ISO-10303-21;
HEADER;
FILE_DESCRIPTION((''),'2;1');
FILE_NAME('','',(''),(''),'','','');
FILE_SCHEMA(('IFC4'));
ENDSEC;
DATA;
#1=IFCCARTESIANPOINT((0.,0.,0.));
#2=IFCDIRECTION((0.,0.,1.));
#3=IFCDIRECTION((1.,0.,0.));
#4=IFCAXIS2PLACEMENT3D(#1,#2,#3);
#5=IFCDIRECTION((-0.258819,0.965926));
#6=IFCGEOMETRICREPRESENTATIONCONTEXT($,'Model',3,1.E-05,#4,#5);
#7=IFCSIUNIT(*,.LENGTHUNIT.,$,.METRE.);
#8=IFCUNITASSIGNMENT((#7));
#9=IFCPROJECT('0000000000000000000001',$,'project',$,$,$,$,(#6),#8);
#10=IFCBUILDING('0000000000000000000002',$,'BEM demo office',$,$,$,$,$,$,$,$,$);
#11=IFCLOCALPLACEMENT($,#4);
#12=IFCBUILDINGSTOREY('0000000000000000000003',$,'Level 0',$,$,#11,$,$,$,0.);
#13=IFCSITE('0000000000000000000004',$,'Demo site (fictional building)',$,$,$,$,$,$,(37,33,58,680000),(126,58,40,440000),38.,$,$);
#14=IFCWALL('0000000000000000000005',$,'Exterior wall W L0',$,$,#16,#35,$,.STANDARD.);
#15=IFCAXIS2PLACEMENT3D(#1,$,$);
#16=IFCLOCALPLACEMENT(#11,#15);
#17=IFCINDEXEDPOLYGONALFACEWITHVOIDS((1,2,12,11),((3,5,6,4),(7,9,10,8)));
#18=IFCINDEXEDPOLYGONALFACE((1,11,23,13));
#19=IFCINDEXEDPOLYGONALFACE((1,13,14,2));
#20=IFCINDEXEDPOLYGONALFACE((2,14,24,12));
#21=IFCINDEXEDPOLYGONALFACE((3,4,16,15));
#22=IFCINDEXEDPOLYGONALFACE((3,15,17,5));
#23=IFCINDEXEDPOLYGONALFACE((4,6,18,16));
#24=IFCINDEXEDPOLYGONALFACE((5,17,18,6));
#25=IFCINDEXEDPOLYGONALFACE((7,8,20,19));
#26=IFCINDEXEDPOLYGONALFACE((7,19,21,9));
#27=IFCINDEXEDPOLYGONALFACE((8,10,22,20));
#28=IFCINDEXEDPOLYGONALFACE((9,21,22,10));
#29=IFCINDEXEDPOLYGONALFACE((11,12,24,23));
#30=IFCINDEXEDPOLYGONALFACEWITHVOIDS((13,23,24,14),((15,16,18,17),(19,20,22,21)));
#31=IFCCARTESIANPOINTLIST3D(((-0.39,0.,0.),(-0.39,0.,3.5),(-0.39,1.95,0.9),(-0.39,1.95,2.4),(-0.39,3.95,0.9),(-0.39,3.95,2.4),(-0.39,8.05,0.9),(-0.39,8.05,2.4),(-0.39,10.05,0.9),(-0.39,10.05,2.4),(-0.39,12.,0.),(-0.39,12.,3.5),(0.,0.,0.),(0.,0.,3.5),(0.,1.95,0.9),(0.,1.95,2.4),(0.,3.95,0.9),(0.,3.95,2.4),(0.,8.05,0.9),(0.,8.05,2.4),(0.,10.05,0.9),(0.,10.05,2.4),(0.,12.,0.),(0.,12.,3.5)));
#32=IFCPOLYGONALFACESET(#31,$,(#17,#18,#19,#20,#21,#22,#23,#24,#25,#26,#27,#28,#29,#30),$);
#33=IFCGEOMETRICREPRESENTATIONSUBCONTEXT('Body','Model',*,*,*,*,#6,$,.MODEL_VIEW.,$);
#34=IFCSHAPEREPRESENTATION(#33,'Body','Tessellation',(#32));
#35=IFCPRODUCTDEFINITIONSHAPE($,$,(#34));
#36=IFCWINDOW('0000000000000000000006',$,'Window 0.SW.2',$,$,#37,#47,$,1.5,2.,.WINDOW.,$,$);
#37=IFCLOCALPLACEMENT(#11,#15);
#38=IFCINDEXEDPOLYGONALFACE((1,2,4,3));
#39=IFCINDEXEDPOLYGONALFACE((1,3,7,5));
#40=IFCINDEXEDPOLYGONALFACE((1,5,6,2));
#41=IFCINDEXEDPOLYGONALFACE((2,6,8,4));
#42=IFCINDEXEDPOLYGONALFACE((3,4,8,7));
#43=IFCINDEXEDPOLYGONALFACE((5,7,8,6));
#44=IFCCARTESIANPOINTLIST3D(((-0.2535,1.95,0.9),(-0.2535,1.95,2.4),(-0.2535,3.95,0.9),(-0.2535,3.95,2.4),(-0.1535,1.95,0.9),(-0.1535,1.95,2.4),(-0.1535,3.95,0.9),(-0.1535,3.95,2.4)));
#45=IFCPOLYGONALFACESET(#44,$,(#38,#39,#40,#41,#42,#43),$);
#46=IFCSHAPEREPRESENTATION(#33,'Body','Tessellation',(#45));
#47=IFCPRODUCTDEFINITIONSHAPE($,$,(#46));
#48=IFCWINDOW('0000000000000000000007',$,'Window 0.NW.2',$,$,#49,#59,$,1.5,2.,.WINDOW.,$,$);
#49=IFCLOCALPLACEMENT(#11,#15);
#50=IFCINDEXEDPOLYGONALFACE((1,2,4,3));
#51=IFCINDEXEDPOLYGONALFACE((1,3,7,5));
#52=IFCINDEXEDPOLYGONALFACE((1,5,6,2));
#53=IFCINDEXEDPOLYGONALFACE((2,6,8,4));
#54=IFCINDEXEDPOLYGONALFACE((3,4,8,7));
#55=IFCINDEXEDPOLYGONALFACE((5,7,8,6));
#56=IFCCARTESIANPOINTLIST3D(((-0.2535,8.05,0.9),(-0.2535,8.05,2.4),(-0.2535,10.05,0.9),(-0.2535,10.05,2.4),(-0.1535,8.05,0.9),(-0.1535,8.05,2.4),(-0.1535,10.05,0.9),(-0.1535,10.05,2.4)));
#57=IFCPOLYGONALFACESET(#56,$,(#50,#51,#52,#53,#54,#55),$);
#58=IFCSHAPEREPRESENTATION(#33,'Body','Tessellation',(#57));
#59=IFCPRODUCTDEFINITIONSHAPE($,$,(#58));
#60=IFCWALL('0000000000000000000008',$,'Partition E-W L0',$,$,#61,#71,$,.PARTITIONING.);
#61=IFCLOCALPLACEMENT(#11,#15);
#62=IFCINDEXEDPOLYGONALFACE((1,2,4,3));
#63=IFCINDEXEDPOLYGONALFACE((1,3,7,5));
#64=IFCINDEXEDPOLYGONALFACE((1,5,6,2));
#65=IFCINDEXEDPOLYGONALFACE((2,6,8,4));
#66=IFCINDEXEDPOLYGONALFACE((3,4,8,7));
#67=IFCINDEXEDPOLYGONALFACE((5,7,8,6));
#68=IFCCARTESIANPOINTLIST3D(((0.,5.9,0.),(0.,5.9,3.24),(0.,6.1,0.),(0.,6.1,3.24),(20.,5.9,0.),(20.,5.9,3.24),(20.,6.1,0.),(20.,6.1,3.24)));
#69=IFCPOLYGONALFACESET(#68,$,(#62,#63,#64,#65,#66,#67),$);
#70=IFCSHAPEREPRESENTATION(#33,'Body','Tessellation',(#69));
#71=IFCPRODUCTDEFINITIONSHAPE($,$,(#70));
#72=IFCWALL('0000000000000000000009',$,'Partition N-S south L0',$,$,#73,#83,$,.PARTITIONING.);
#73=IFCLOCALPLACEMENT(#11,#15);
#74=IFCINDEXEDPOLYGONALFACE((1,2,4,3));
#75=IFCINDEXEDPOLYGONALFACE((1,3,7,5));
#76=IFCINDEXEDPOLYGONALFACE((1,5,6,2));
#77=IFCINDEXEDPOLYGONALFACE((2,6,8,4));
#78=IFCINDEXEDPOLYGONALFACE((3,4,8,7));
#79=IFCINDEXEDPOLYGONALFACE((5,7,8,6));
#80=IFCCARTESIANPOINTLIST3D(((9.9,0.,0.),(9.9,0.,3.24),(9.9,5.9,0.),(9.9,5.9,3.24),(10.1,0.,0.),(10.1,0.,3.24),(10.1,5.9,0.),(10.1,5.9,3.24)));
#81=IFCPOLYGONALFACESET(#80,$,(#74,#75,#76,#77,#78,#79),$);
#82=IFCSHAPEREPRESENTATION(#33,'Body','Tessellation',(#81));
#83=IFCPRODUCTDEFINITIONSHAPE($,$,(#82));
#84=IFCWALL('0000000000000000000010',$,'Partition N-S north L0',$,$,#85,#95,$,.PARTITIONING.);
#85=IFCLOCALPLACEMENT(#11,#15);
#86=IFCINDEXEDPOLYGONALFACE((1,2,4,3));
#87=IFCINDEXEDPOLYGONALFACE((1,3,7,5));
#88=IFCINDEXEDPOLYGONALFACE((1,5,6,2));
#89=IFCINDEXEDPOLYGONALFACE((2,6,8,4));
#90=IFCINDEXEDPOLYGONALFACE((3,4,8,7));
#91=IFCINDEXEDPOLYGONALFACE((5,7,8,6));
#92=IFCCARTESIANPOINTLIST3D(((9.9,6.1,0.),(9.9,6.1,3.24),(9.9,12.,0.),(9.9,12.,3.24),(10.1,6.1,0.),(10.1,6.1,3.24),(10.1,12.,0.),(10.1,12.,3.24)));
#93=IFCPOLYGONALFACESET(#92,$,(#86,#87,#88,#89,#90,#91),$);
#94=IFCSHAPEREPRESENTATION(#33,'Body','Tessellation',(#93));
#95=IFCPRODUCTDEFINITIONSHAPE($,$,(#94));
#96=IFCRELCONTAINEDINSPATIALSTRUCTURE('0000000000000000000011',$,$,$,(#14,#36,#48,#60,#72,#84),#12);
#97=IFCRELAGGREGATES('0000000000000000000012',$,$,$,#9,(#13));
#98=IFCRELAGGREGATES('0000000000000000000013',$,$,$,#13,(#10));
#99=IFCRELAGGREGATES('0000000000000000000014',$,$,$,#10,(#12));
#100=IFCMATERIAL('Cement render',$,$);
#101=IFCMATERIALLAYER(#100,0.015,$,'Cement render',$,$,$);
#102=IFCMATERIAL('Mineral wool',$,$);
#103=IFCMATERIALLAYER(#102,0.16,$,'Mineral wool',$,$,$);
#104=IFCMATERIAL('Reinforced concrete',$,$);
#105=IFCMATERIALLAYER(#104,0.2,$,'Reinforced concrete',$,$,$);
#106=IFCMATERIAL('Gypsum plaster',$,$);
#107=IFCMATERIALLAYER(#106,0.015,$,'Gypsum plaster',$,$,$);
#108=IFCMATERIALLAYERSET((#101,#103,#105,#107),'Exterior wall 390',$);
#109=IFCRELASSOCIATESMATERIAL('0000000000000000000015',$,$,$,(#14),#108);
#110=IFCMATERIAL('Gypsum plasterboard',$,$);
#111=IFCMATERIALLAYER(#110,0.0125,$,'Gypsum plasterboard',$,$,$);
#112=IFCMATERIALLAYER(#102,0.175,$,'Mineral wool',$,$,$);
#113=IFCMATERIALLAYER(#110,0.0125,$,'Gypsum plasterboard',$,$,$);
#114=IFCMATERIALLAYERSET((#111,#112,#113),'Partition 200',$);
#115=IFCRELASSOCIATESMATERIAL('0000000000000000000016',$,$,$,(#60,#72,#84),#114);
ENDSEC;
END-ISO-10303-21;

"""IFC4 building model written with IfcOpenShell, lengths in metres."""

from ifc_helpers import new_model, si_unit, direction, frame, frame_2d, origin, origin_with_axes, place, context, subcontext, project, spatial, rectangle, extrude, material, layer, layer_set, layer_usage, element, fill, save


model = new_model("IFC4")

# Units and contexts
model_context = context("Model", 3, precision=1e-05, world=origin_with_axes(), true_north=direction((-0.258819, 0.965926)))
body_context = subcontext(model_context, "Body", "Model", "MODEL_VIEW")
ifc_project = project(units=[si_unit("LENGTHUNIT", "METRE")], contexts=[model_context])

# Site, building, storey
site = spatial("IfcSite", under=ifc_project, Name="Demo site (fictional building)", RefLatitude=(37, 33, 58, 680000), RefLongitude=(126, 58, 40, 440000), RefElevation=38.0)
building = spatial("IfcBuilding", under=site, Name="BEM demo office")
storey_placement = place(None, origin_with_axes())
storey = spatial("IfcBuildingStorey", under=building, at=storey_placement, Name="Level 0", Elevation=0.0)

# Shared definitions
ifc_material_1 = material(Name="Reinforced concrete")

# Wall, openings, windows
ifc_material_2 = material(Name="Cement render")
ifc_layer_1 = layer(ifc_material_2, 0.015, Name="Cement render")
ifc_material_3 = material(Name="Mineral wool")
ifc_layer_2 = layer(ifc_material_3, 0.16, Name="Mineral wool")
ifc_layer_3 = layer(ifc_material_1, 0.2, Name="Reinforced concrete")
ifc_material_4 = material(Name="Gypsum plaster")
ifc_layer_4 = layer(ifc_material_4, 0.015, Name="Gypsum plaster")
ifc_layer_set_1 = layer_set([ifc_layer_1, ifc_layer_2, ifc_layer_3, ifc_layer_4], Name="Exterior wall 390")
ifc_layer_usage_1 = layer_usage(ifc_layer_set_1, "AXIS2", "POSITIVE", 0.0)
wall_1_placement = place(storey_placement, frame((-0.39, 12.0, 0.0), z_axis=(0.0, 0.0, 1.0), x_axis=(0.0, -1.0, 0.0)))
wall_1 = element("IfcWall", 1, at=wall_1_placement, inside=storey, material=ifc_layer_usage_1, Name="Exterior wall W L0", PredefinedType="STANDARD", context=body_context, shape_type="SweptSolid", body=[
    extrude(rectangle(XDim=12.0, YDim=0.39, at=frame_2d((6.0, 0.195))), origin(), (0.0, 0.0, 1.0), 3.5),
])
opening_1_placement = place(wall_1_placement, origin())
opening_1 = element("IfcOpeningElement", 2, at=opening_1_placement, cuts=wall_1, PredefinedType="OPENING", context=body_context, shape_type="SweptSolid", body=[
    extrude(rectangle(XDim=2.0, YDim=0.49, at=frame_2d((1.0, 0.245))), frame((8.05, -0.05, 0.9)), (0.0, 0.0, 1.0), 1.5),
])
opening_2_placement = place(wall_1_placement, origin())
opening_2 = element("IfcOpeningElement", 3, at=opening_2_placement, cuts=wall_1, PredefinedType="OPENING", context=body_context, shape_type="SweptSolid", body=[
    extrude(rectangle(XDim=2.0, YDim=0.49, at=frame_2d((1.0, 0.245))), frame((1.95, -0.05, 0.9)), (0.0, 0.0, 1.0), 1.5),
])
window_1_placement = place(opening_1_placement, origin_with_axes())
window_1 = element("IfcWindow", 4, at=window_1_placement, inside=storey, Name="Window 0.SW.2", OverallHeight=1.5, OverallWidth=2.0, PredefinedType="WINDOW", context=body_context, shape_type="SweptSolid", body=[
    extrude(rectangle(XDim=2.0, YDim=0.1, at=frame_2d((1.0, 0.05))), frame((8.05, 0.1365, 0.9)), (0.0, 0.0, 1.0), 1.5),
])
fill(opening_1, window_1)
window_2_placement = place(opening_2_placement, origin_with_axes())
window_2 = element("IfcWindow", 5, at=window_2_placement, inside=storey, Name="Window 0.NW.2", OverallHeight=1.5, OverallWidth=2.0, PredefinedType="WINDOW", context=body_context, shape_type="SweptSolid", body=[
    extrude(rectangle(XDim=2.0, YDim=0.1, at=frame_2d((1.0, 0.05))), frame((1.95, 0.1365, 0.9)), (0.0, 0.0, 1.0), 1.5),
])
fill(opening_2, window_2)

# Walls
ifc_material_5 = material(Name="Gypsum plasterboard")
ifc_layer_5 = layer(ifc_material_5, 0.0125, Name="Gypsum plasterboard")
ifc_layer_6 = layer(ifc_material_3, 0.175, Name="Mineral wool")
ifc_layer_7 = layer(ifc_material_5, 0.0125, Name="Gypsum plasterboard")
ifc_layer_set_2 = layer_set([ifc_layer_5, ifc_layer_6, ifc_layer_7], Name="Partition 200")
ifc_layer_usage_2 = layer_usage(ifc_layer_set_2, "AXIS2", "POSITIVE", 0.0)
wall_2_placement = place(storey_placement, frame((0.0, 5.9, 0.0), z_axis=(0.0, 0.0, 1.0), x_axis=(1.0, 0.0, 0.0)))
element("IfcWall", 6, at=wall_2_placement, inside=storey, material=ifc_layer_usage_2, Name="Partition E-W L0", PredefinedType="PARTITIONING", context=body_context, shape_type="SweptSolid", body=[
    extrude(rectangle(XDim=20.0, YDim=0.2, at=frame_2d((10.0, 0.1))), origin(), (0.0, 0.0, 1.0), 3.24),
])
for number, where, z_axis, x_axis, name in (
    (7, (10.1, 0.0, 0.0), (0.0, 0.0, 1.0), (0.0, 1.0, 0.0), "Partition N-S south L0"),
    (8, (10.1, 6.1, 0.0), (0.0, 0.0, 1.0), (0.0, 1.0, 0.0), "Partition N-S north L0"),
):
    element("IfcWall", number, at=place(storey_placement, frame(where, z_axis=z_axis, x_axis=x_axis)), inside=storey, material=ifc_layer_usage_2, Name=name, PredefinedType="PARTITIONING", context=body_context, shape_type="SweptSolid", body=[
        extrude(rectangle(XDim=5.9, YDim=0.2, at=frame_2d((2.95, 0.1))), origin(), (0.0, 0.0, 1.0), 3.24),
    ])

save(model, "model.ifc")
